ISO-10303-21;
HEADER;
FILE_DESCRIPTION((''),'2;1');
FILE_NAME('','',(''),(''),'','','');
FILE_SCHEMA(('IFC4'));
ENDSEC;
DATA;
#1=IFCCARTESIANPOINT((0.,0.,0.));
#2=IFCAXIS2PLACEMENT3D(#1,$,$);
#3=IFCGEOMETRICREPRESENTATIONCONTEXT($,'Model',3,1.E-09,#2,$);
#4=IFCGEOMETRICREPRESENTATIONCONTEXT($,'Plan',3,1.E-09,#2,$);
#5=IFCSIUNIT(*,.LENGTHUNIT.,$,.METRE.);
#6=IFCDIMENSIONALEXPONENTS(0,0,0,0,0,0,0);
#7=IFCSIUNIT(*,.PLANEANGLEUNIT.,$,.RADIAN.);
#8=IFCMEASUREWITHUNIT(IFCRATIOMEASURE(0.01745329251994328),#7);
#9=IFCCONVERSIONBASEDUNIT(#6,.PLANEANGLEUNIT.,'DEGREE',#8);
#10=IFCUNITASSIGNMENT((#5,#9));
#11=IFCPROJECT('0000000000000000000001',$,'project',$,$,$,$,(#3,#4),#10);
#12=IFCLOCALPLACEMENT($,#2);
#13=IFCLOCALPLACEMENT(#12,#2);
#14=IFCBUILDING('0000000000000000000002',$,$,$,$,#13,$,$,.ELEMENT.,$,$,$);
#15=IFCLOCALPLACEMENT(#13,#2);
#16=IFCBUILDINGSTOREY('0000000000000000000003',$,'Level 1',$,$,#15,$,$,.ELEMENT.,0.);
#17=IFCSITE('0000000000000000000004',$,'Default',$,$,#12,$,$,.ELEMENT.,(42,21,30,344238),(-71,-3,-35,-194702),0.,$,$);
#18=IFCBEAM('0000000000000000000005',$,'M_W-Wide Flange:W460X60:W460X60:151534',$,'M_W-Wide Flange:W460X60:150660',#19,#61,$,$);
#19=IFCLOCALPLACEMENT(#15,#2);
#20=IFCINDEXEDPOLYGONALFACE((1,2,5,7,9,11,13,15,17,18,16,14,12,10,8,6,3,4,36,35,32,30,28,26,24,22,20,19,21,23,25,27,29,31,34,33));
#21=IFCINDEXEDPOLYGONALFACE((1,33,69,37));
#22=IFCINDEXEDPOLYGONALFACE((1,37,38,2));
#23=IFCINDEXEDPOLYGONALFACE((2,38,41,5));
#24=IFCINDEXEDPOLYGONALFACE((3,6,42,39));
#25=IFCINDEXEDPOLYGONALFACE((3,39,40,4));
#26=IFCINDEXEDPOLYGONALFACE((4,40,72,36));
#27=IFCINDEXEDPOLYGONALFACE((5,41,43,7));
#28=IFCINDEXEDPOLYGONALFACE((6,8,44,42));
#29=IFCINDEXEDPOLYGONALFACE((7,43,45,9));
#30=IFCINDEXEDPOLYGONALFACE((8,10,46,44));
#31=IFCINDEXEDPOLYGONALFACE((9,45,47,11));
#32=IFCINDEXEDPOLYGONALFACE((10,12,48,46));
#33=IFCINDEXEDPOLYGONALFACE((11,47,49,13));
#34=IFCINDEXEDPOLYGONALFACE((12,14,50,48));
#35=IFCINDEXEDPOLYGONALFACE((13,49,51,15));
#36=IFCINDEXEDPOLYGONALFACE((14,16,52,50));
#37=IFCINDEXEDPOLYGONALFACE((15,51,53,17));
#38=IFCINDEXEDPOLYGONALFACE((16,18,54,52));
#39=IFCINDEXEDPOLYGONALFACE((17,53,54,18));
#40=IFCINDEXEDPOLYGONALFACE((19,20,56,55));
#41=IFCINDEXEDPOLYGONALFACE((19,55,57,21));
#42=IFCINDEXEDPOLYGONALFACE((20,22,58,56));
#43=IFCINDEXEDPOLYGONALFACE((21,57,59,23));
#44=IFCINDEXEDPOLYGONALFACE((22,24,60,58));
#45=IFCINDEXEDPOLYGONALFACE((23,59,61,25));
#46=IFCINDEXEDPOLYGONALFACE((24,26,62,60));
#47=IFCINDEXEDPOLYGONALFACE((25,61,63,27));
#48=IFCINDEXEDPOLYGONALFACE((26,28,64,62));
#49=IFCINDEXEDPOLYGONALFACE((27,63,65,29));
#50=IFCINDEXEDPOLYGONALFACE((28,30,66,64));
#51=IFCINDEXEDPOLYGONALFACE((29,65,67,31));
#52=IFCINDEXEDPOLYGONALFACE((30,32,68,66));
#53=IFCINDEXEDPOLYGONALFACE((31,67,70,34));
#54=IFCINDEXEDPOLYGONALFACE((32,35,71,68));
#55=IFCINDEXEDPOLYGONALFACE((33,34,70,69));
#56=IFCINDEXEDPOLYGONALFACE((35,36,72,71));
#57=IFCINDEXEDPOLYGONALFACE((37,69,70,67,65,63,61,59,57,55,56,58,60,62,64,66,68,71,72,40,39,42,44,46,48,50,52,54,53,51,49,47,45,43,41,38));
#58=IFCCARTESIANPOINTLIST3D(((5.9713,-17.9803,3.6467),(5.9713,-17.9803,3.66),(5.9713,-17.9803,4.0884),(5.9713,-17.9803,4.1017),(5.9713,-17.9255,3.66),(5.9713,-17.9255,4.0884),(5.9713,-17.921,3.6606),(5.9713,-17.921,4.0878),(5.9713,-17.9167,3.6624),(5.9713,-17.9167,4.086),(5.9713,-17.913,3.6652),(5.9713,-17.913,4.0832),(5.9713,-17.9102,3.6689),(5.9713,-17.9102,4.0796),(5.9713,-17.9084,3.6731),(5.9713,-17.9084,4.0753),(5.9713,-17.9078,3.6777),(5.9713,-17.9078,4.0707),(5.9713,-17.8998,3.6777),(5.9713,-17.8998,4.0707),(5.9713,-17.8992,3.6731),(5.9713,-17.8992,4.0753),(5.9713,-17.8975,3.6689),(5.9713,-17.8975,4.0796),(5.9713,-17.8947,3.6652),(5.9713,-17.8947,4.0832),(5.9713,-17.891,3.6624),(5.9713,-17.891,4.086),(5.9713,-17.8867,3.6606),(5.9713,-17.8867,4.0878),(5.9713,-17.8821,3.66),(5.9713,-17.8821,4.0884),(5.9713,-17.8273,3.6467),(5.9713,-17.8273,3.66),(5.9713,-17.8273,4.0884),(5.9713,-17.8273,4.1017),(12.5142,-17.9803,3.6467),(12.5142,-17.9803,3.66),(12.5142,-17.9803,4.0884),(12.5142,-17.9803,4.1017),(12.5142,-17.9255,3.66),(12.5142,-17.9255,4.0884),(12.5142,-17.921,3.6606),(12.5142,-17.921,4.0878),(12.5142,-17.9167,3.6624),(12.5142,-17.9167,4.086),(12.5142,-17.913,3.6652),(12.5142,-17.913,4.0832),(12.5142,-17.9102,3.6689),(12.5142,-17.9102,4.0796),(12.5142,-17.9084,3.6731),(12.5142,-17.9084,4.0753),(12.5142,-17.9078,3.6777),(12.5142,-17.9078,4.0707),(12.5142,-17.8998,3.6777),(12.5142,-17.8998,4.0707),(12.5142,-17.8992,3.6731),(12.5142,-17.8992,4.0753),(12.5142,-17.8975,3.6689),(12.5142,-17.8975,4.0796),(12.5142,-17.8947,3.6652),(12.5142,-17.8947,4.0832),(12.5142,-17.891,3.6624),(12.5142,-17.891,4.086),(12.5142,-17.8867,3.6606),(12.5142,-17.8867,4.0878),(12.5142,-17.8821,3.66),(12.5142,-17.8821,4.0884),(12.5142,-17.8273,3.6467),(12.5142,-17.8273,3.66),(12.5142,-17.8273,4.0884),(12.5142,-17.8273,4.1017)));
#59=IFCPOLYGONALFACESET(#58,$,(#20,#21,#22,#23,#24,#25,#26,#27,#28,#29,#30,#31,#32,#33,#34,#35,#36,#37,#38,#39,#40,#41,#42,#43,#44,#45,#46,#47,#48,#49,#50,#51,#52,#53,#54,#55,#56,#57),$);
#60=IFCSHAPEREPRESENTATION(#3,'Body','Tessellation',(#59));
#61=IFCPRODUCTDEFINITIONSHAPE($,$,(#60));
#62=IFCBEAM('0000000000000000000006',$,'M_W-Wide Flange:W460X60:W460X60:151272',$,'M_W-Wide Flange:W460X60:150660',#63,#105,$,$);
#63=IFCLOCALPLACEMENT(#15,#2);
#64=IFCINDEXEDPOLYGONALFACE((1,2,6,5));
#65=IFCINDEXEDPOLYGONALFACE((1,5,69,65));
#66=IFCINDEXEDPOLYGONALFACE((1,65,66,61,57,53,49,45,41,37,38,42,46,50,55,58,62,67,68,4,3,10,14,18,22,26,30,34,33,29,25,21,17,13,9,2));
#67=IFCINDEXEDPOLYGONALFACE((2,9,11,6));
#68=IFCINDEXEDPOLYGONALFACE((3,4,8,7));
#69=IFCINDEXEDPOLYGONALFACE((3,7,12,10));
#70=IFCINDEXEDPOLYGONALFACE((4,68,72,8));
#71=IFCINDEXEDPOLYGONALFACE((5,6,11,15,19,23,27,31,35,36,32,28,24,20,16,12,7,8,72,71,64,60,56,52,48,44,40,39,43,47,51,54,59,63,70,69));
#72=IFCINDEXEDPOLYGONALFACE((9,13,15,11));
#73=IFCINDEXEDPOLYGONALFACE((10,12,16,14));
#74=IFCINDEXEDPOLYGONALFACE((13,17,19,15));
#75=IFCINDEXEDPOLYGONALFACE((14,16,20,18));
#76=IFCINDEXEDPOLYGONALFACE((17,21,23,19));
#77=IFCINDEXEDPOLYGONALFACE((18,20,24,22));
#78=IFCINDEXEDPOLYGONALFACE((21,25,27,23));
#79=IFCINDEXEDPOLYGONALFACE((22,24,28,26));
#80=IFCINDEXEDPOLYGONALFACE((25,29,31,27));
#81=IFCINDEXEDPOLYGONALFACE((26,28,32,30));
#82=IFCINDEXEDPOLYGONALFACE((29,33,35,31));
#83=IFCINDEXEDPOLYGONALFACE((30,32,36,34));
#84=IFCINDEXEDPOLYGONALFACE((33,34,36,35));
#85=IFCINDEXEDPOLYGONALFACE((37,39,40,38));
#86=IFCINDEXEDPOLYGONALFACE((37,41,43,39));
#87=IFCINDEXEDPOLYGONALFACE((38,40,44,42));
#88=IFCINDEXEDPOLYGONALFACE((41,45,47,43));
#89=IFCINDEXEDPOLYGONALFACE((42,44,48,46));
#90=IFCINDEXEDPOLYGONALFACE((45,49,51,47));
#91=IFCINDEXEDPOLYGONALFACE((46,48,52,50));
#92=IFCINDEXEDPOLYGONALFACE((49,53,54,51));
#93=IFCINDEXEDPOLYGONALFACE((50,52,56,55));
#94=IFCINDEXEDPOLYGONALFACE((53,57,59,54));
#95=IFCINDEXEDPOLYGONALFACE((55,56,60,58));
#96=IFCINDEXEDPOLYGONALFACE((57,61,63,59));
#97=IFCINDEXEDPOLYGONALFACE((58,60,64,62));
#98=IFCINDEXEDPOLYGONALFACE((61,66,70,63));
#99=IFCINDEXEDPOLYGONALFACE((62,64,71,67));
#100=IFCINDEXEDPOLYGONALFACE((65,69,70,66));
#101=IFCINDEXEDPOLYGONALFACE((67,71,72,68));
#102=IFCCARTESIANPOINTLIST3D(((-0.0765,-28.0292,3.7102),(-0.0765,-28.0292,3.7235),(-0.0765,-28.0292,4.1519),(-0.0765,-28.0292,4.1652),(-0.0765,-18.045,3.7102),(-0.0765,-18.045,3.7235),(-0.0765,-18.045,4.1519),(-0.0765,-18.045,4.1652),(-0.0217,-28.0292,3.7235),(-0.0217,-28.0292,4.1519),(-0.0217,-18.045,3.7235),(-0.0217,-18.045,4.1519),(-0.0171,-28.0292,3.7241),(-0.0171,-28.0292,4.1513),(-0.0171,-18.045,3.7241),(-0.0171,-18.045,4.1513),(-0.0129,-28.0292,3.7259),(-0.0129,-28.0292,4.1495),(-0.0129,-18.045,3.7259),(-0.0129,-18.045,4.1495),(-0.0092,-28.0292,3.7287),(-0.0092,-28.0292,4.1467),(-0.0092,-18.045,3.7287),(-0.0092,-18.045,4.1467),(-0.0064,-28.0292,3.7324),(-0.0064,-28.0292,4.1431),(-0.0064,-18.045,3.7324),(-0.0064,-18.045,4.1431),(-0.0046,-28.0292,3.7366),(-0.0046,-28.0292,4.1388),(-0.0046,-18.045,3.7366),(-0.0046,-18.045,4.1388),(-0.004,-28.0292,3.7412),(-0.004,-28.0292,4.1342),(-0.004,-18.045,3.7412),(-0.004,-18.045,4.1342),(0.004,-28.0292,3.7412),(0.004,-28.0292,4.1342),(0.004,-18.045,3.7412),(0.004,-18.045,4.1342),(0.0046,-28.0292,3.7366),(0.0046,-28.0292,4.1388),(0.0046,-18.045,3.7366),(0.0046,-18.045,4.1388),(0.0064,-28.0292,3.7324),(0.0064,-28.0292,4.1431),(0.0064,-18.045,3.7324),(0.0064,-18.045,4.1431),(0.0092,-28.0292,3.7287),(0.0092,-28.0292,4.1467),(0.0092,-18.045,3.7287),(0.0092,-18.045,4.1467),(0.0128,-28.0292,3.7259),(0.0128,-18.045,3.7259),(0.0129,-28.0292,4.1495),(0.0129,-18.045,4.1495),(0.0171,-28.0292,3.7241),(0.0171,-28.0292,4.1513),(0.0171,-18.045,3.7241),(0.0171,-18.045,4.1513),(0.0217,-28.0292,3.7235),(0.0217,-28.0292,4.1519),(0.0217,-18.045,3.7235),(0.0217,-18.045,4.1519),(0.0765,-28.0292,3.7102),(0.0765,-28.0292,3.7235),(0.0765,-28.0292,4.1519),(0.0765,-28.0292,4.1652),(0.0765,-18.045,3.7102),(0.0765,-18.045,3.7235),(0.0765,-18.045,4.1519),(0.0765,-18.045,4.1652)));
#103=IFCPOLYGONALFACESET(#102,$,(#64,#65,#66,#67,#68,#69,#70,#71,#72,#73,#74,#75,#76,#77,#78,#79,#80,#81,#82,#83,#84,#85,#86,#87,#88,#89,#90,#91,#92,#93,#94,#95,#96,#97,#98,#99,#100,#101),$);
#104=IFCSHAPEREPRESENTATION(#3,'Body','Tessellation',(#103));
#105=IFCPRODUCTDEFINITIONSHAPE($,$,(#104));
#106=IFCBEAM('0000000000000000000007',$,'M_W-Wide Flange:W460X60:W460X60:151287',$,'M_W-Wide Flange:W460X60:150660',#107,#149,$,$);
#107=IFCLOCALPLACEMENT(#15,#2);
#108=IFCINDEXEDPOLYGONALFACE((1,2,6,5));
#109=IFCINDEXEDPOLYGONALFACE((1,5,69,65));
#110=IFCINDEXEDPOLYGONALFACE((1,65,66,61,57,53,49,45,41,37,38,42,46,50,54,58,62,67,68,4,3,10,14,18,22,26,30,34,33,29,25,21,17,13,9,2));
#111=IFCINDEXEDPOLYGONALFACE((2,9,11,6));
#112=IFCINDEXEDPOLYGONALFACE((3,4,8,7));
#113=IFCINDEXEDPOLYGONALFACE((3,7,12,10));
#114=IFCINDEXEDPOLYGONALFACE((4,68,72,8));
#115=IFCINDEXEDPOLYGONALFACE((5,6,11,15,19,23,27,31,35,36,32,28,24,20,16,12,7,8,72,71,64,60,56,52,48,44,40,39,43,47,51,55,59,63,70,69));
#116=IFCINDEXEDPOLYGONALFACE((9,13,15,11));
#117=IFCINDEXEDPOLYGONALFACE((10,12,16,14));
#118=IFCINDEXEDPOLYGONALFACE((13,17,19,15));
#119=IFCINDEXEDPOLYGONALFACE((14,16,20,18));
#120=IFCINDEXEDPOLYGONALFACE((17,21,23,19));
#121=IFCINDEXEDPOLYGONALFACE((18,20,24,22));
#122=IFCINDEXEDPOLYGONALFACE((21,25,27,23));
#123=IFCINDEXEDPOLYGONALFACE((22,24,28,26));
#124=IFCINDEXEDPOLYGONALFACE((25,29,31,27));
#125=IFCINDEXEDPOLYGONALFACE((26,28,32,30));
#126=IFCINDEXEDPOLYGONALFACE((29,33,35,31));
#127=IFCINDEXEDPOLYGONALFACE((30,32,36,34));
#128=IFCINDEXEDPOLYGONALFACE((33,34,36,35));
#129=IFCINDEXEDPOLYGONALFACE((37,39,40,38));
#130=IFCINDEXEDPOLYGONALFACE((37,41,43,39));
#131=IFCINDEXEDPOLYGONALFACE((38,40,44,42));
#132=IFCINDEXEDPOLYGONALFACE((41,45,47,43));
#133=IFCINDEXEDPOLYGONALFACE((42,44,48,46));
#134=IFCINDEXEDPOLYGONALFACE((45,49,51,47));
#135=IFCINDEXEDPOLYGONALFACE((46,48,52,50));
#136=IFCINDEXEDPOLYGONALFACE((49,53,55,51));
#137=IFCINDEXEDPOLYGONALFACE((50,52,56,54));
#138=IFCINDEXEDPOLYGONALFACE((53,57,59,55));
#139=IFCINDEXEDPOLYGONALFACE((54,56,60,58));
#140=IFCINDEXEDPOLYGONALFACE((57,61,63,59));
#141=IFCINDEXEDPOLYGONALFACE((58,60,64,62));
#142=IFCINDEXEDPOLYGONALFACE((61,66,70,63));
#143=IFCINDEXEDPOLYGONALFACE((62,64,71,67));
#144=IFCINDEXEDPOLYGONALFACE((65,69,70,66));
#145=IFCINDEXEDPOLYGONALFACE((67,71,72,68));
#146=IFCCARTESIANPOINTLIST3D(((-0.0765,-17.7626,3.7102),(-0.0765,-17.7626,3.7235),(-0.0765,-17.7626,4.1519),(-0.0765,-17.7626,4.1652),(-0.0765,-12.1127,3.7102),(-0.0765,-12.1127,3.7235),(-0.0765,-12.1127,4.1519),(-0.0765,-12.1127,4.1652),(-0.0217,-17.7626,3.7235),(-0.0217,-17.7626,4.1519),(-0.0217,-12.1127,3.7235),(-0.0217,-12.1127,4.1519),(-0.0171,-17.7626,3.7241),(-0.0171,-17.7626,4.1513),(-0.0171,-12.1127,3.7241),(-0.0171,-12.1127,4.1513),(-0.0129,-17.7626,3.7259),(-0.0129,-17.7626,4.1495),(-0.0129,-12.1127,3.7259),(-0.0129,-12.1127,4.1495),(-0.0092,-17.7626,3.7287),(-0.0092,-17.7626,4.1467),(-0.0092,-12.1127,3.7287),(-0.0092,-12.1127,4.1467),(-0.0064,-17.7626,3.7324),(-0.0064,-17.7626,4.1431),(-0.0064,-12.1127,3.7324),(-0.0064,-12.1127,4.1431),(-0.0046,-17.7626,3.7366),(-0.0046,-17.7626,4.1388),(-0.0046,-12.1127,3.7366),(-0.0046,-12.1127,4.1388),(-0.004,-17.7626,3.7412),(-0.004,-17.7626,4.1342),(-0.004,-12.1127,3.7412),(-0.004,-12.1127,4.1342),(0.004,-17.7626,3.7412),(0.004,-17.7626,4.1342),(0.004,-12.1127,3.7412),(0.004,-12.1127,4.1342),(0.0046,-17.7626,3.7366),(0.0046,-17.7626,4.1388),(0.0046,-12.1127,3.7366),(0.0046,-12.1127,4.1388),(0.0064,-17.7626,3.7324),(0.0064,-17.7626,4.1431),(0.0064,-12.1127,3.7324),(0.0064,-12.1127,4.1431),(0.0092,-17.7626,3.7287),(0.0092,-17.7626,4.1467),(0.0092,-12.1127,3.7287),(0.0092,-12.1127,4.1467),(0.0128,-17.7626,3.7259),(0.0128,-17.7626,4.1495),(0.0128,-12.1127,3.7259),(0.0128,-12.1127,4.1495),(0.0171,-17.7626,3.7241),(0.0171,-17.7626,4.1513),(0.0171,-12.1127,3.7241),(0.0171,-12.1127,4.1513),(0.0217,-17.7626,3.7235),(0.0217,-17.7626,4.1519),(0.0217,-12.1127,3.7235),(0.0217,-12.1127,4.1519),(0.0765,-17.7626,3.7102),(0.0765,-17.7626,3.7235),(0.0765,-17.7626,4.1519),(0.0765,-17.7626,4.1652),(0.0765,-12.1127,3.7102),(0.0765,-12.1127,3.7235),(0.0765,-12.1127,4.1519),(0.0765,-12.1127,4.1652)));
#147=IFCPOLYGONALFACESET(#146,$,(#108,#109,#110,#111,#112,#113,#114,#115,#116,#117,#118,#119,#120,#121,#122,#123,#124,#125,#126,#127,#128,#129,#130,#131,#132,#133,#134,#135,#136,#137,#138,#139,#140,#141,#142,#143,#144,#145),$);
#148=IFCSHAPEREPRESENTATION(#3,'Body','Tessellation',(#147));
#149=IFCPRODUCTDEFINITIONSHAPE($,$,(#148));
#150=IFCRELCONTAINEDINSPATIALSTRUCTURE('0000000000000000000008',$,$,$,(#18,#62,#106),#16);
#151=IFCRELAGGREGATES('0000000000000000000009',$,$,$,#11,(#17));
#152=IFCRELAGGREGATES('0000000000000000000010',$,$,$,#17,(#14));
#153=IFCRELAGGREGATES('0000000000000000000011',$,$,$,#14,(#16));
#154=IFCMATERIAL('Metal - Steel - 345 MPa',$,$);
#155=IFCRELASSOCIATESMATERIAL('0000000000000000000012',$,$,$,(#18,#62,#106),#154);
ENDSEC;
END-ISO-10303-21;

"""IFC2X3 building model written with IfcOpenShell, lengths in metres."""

from ifc_helpers import new_model, entity, si_unit, converted_unit, frame, frame_2d, origin, place, context, project, spatial, polyline, circle_curve, parameter, trimmed, segment, composite_curve, outline, extrude, material, element, save


model = new_model("IFC2X3")

# Units and contexts
model_context = context("Model", 3, precision=1e-09, world=origin())
plan_context = context("Plan", 3, precision=1e-09, world=origin())
ifc_project = project(units=[si_unit("LENGTHUNIT", "METRE"), converted_unit("PLANEANGLEUNIT", "DEGREE", entity("IfcRatioMeasure", 0.01745329251994328), si_unit("PLANEANGLEUNIT", "RADIAN"), dimensions=[0, 0, 0, 0, 0, 0, 0])], contexts=[model_context, plan_context])

# Site, building, storey
site_placement = place(None, origin())
site = spatial("IfcSite", under=ifc_project, at=site_placement, Name="Default", CompositionType="ELEMENT", RefLatitude=(42, 21, 30, 344238), RefLongitude=(-71, -3, -35, -194702), RefElevation=0.0)
building_placement = place(site_placement, origin())
building = spatial("IfcBuilding", under=site, at=building_placement, CompositionType="ELEMENT")
storey_placement = place(building_placement, origin())
storey = spatial("IfcBuildingStorey", under=building, at=storey_placement, Name="Level 1", CompositionType="ELEMENT", Elevation=0.0)

# Beams
ifc_material_1 = material(Name="Metal - Steel - 345 MPa")
beam_1_placement = place(storey_placement, frame((12.6289, -17.9038, 4.2672), z_axis=(0.0, 0.0, 1.0), x_axis=(0.0, 1.0, 0.0)))
element("IfcBeam", 1, at=beam_1_placement, inside=storey, material=ifc_material_1, Name="M_W-Wide Flange:W460X60:W460X60:151534", ObjectType="M_W-Wide Flange:W460X60:150660", context=model_context, shape_type="SweptSolid", body=[
    extrude(outline(composite_curve([segment(polyline([(0.2142, -0.0765), (0.2275, -0.0765)]), True, "CONTINUOUS"), segment(polyline([(0.2275, -0.0765), (0.2275, 0.0765)]), True, "CONTINUOUS"), segment(polyline([(0.2275, 0.0765), (0.2142, 0.0765)]), True, "CONTINUOUS"), segment(polyline([(0.2142, 0.0765), (0.2142, 0.0217)]), True, "CONTINUOUS"), segment(trimmed(circle_curve(frame_2d((0.1965, 0.0217), x_axis=(1.0, 0.0)), 0.0177), [parameter(270.0)], [parameter(360.0)], True, "PARAMETER"), False, "CONTINUOUS"), segment(polyline([(0.1965, 0.004), (-0.1965, 0.004)]), True, "CONTINUOUS"), segment(trimmed(circle_curve(frame_2d((-0.1965, 0.0217), x_axis=(0.0, -1.0)), 0.0177), [parameter(270.0)], [parameter(360.0)], True, "PARAMETER"), False, "CONTINUOUS"), segment(polyline([(-0.2142, 0.0217), (-0.2142, 0.0765)]), True, "CONTINUOUS"), segment(polyline([(-0.2142, 0.0765), (-0.2275, 0.0765)]), True, "CONTINUOUS"), segment(polyline([(-0.2275, 0.0765), (-0.2275, -0.0765)]), True, "CONTINUOUS"), segment(polyline([(-0.2275, -0.0765), (-0.2142, -0.0765)]), True, "CONTINUOUS"), segment(polyline([(-0.2142, -0.0765), (-0.2142, -0.0217)]), True, "CONTINUOUS"), segment(trimmed(circle_curve(frame_2d((-0.1965, -0.0217), x_axis=(-1.0, 0.0)), 0.0177), [parameter(270.0)], [parameter(360.0)], True, "PARAMETER"), False, "CONTINUOUS"), segment(polyline([(-0.1965, -0.004), (0.1965, -0.004)]), True, "CONTINUOUS"), segment(trimmed(circle_curve(frame_2d((0.1965, -0.0217), x_axis=(0.0, 1.0)), 0.0177), [parameter(270.0)], [parameter(0.0)], True, "PARAMETER"), False, "CONTINUOUS"), segment(polyline([(0.2142, -0.0217), (0.2142, -0.0765)]), True, "CONTINUOUS")], self_intersect=False)), frame((0.0, 6.6576, -0.393), z_axis=(0.0, -1.0, 0.0), x_axis=(0.0, 0.0, -1.0)), (0.0, 0.0, 1.0), 6.5429),
])
beam_2_placement = place(storey_placement, frame((0.0, -28.1704, 4.2672)))
element("IfcBeam", 2, at=beam_2_placement, inside=storey, material=ifc_material_1, Name="M_W-Wide Flange:W460X60:W460X60:151272", ObjectType="M_W-Wide Flange:W460X60:150660", context=model_context, shape_type="SweptSolid", body=[
    extrude(outline(composite_curve([segment(polyline([(-0.0765, -0.2142), (-0.0765, -0.2275)]), True, "CONTINUOUS"), segment(polyline([(-0.0765, -0.2275), (0.0765, -0.2275)]), True, "CONTINUOUS"), segment(polyline([(0.0765, -0.2275), (0.0765, -0.2142)]), True, "CONTINUOUS"), segment(polyline([(0.0765, -0.2142), (0.0217, -0.2142)]), True, "CONTINUOUS"), segment(trimmed(circle_curve(frame_2d((0.0217, -0.1965), x_axis=(0.0, -1.0)), 0.0177), [parameter(270.0)], [parameter(360.0)], True, "PARAMETER"), False, "CONTINUOUS"), segment(polyline([(0.004, -0.1965), (0.004, 0.1965)]), True, "CONTINUOUS"), segment(trimmed(circle_curve(frame_2d((0.0217, 0.1965), x_axis=(-1.0, 0.0)), 0.0177), [parameter(270.0)], [parameter(360.0)], True, "PARAMETER"), False, "CONTINUOUS"), segment(polyline([(0.0217, 0.2142), (0.0765, 0.2142)]), True, "CONTINUOUS"), segment(polyline([(0.0765, 0.2142), (0.0765, 0.2275)]), True, "CONTINUOUS"), segment(polyline([(0.0765, 0.2275), (-0.0765, 0.2275)]), True, "CONTINUOUS"), segment(polyline([(-0.0765, 0.2275), (-0.0765, 0.2142)]), True, "CONTINUOUS"), segment(polyline([(-0.0765, 0.2142), (-0.0217, 0.2142)]), True, "CONTINUOUS"), segment(trimmed(circle_curve(frame_2d((-0.0217, 0.1965), x_axis=(0.0, 1.0)), 0.0177), [parameter(270.0)], [parameter(360.0)], True, "PARAMETER"), False, "CONTINUOUS"), segment(polyline([(-0.004, 0.1965), (-0.004, -0.1965)]), True, "CONTINUOUS"), segment(trimmed(circle_curve(frame_2d((-0.0217, -0.1965), x_axis=(1.0, 0.0)), 0.0177), [parameter(270.0)], [parameter(0.0)], True, "PARAMETER"), False, "CONTINUOUS"), segment(polyline([(-0.0217, -0.2142), (-0.0765, -0.2142)]), True, "CONTINUOUS")], self_intersect=False)), frame((0.0, 0.1412, -0.3295), z_axis=(0.0, -1.0, 0.0), x_axis=(1.0, 0.0, 0.0)), (0.0, 0.0, -1.0), 9.9841),
])
beam_3_placement = place(storey_placement, frame((0.0, -17.9038, 4.2672)))
element("IfcBeam", 3, at=beam_3_placement, inside=storey, material=ifc_material_1, Name="M_W-Wide Flange:W460X60:W460X60:151287", ObjectType="M_W-Wide Flange:W460X60:150660", context=model_context, shape_type="SweptSolid", body=[
    extrude(outline(composite_curve([segment(polyline([(-0.0765, -0.2142), (-0.0765, -0.2275)]), True, "CONTINUOUS"), segment(polyline([(-0.0765, -0.2275), (0.0765, -0.2275)]), True, "CONTINUOUS"), segment(polyline([(0.0765, -0.2275), (0.0765, -0.2142)]), True, "CONTINUOUS"), segment(polyline([(0.0765, -0.2142), (0.0217, -0.2142)]), True, "CONTINUOUS"), segment(trimmed(circle_curve(frame_2d((0.0217, -0.1965), x_axis=(1.0, 0.0)), 0.0177), [parameter(180.0)], [parameter(270.0)], True, "PARAMETER"), False, "CONTINUOUS"), segment(polyline([(0.004, -0.1965), (0.004, 0.1965)]), True, "CONTINUOUS"), segment(trimmed(circle_curve(frame_2d((0.0217, 0.1965), x_axis=(1.0, 0.0)), 0.0177), [parameter(90.0)], [parameter(180.0)], True, "PARAMETER"), False, "CONTINUOUS"), segment(polyline([(0.0217, 0.2142), (0.0765, 0.2142)]), True, "CONTINUOUS"), segment(polyline([(0.0765, 0.2142), (0.0765, 0.2275)]), True, "CONTINUOUS"), segment(polyline([(0.0765, 0.2275), (-0.0765, 0.2275)]), True, "CONTINUOUS"), segment(polyline([(-0.0765, 0.2275), (-0.0765, 0.2142)]), True, "CONTINUOUS"), segment(polyline([(-0.0765, 0.2142), (-0.0217, 0.2142)]), True, "CONTINUOUS"), segment(trimmed(circle_curve(frame_2d((-0.0217, 0.1965), x_axis=(1.0, 0.0)), 0.0177), [parameter(360.0)], [parameter(90.0)], True, "PARAMETER"), False, "CONTINUOUS"), segment(polyline([(-0.004, 0.1965), (-0.004, -0.1965)]), True, "CONTINUOUS"), segment(trimmed(circle_curve(frame_2d((-0.0217, -0.1965), x_axis=(1.0, 0.0)), 0.0177), [parameter(270.0)], [parameter(0.0)], True, "PARAMETER"), False, "CONTINUOUS"), segment(polyline([(-0.0217, -0.2142), (-0.0765, -0.2142)]), True, "CONTINUOUS")], self_intersect=False)), frame((0.0, 0.1412, -0.3295), z_axis=(0.0, -1.0, 0.0), x_axis=(1.0, 0.0, 0.0)), (0.0, 0.0, -1.0), 5.65),
])

save(model, "model.ifc")
